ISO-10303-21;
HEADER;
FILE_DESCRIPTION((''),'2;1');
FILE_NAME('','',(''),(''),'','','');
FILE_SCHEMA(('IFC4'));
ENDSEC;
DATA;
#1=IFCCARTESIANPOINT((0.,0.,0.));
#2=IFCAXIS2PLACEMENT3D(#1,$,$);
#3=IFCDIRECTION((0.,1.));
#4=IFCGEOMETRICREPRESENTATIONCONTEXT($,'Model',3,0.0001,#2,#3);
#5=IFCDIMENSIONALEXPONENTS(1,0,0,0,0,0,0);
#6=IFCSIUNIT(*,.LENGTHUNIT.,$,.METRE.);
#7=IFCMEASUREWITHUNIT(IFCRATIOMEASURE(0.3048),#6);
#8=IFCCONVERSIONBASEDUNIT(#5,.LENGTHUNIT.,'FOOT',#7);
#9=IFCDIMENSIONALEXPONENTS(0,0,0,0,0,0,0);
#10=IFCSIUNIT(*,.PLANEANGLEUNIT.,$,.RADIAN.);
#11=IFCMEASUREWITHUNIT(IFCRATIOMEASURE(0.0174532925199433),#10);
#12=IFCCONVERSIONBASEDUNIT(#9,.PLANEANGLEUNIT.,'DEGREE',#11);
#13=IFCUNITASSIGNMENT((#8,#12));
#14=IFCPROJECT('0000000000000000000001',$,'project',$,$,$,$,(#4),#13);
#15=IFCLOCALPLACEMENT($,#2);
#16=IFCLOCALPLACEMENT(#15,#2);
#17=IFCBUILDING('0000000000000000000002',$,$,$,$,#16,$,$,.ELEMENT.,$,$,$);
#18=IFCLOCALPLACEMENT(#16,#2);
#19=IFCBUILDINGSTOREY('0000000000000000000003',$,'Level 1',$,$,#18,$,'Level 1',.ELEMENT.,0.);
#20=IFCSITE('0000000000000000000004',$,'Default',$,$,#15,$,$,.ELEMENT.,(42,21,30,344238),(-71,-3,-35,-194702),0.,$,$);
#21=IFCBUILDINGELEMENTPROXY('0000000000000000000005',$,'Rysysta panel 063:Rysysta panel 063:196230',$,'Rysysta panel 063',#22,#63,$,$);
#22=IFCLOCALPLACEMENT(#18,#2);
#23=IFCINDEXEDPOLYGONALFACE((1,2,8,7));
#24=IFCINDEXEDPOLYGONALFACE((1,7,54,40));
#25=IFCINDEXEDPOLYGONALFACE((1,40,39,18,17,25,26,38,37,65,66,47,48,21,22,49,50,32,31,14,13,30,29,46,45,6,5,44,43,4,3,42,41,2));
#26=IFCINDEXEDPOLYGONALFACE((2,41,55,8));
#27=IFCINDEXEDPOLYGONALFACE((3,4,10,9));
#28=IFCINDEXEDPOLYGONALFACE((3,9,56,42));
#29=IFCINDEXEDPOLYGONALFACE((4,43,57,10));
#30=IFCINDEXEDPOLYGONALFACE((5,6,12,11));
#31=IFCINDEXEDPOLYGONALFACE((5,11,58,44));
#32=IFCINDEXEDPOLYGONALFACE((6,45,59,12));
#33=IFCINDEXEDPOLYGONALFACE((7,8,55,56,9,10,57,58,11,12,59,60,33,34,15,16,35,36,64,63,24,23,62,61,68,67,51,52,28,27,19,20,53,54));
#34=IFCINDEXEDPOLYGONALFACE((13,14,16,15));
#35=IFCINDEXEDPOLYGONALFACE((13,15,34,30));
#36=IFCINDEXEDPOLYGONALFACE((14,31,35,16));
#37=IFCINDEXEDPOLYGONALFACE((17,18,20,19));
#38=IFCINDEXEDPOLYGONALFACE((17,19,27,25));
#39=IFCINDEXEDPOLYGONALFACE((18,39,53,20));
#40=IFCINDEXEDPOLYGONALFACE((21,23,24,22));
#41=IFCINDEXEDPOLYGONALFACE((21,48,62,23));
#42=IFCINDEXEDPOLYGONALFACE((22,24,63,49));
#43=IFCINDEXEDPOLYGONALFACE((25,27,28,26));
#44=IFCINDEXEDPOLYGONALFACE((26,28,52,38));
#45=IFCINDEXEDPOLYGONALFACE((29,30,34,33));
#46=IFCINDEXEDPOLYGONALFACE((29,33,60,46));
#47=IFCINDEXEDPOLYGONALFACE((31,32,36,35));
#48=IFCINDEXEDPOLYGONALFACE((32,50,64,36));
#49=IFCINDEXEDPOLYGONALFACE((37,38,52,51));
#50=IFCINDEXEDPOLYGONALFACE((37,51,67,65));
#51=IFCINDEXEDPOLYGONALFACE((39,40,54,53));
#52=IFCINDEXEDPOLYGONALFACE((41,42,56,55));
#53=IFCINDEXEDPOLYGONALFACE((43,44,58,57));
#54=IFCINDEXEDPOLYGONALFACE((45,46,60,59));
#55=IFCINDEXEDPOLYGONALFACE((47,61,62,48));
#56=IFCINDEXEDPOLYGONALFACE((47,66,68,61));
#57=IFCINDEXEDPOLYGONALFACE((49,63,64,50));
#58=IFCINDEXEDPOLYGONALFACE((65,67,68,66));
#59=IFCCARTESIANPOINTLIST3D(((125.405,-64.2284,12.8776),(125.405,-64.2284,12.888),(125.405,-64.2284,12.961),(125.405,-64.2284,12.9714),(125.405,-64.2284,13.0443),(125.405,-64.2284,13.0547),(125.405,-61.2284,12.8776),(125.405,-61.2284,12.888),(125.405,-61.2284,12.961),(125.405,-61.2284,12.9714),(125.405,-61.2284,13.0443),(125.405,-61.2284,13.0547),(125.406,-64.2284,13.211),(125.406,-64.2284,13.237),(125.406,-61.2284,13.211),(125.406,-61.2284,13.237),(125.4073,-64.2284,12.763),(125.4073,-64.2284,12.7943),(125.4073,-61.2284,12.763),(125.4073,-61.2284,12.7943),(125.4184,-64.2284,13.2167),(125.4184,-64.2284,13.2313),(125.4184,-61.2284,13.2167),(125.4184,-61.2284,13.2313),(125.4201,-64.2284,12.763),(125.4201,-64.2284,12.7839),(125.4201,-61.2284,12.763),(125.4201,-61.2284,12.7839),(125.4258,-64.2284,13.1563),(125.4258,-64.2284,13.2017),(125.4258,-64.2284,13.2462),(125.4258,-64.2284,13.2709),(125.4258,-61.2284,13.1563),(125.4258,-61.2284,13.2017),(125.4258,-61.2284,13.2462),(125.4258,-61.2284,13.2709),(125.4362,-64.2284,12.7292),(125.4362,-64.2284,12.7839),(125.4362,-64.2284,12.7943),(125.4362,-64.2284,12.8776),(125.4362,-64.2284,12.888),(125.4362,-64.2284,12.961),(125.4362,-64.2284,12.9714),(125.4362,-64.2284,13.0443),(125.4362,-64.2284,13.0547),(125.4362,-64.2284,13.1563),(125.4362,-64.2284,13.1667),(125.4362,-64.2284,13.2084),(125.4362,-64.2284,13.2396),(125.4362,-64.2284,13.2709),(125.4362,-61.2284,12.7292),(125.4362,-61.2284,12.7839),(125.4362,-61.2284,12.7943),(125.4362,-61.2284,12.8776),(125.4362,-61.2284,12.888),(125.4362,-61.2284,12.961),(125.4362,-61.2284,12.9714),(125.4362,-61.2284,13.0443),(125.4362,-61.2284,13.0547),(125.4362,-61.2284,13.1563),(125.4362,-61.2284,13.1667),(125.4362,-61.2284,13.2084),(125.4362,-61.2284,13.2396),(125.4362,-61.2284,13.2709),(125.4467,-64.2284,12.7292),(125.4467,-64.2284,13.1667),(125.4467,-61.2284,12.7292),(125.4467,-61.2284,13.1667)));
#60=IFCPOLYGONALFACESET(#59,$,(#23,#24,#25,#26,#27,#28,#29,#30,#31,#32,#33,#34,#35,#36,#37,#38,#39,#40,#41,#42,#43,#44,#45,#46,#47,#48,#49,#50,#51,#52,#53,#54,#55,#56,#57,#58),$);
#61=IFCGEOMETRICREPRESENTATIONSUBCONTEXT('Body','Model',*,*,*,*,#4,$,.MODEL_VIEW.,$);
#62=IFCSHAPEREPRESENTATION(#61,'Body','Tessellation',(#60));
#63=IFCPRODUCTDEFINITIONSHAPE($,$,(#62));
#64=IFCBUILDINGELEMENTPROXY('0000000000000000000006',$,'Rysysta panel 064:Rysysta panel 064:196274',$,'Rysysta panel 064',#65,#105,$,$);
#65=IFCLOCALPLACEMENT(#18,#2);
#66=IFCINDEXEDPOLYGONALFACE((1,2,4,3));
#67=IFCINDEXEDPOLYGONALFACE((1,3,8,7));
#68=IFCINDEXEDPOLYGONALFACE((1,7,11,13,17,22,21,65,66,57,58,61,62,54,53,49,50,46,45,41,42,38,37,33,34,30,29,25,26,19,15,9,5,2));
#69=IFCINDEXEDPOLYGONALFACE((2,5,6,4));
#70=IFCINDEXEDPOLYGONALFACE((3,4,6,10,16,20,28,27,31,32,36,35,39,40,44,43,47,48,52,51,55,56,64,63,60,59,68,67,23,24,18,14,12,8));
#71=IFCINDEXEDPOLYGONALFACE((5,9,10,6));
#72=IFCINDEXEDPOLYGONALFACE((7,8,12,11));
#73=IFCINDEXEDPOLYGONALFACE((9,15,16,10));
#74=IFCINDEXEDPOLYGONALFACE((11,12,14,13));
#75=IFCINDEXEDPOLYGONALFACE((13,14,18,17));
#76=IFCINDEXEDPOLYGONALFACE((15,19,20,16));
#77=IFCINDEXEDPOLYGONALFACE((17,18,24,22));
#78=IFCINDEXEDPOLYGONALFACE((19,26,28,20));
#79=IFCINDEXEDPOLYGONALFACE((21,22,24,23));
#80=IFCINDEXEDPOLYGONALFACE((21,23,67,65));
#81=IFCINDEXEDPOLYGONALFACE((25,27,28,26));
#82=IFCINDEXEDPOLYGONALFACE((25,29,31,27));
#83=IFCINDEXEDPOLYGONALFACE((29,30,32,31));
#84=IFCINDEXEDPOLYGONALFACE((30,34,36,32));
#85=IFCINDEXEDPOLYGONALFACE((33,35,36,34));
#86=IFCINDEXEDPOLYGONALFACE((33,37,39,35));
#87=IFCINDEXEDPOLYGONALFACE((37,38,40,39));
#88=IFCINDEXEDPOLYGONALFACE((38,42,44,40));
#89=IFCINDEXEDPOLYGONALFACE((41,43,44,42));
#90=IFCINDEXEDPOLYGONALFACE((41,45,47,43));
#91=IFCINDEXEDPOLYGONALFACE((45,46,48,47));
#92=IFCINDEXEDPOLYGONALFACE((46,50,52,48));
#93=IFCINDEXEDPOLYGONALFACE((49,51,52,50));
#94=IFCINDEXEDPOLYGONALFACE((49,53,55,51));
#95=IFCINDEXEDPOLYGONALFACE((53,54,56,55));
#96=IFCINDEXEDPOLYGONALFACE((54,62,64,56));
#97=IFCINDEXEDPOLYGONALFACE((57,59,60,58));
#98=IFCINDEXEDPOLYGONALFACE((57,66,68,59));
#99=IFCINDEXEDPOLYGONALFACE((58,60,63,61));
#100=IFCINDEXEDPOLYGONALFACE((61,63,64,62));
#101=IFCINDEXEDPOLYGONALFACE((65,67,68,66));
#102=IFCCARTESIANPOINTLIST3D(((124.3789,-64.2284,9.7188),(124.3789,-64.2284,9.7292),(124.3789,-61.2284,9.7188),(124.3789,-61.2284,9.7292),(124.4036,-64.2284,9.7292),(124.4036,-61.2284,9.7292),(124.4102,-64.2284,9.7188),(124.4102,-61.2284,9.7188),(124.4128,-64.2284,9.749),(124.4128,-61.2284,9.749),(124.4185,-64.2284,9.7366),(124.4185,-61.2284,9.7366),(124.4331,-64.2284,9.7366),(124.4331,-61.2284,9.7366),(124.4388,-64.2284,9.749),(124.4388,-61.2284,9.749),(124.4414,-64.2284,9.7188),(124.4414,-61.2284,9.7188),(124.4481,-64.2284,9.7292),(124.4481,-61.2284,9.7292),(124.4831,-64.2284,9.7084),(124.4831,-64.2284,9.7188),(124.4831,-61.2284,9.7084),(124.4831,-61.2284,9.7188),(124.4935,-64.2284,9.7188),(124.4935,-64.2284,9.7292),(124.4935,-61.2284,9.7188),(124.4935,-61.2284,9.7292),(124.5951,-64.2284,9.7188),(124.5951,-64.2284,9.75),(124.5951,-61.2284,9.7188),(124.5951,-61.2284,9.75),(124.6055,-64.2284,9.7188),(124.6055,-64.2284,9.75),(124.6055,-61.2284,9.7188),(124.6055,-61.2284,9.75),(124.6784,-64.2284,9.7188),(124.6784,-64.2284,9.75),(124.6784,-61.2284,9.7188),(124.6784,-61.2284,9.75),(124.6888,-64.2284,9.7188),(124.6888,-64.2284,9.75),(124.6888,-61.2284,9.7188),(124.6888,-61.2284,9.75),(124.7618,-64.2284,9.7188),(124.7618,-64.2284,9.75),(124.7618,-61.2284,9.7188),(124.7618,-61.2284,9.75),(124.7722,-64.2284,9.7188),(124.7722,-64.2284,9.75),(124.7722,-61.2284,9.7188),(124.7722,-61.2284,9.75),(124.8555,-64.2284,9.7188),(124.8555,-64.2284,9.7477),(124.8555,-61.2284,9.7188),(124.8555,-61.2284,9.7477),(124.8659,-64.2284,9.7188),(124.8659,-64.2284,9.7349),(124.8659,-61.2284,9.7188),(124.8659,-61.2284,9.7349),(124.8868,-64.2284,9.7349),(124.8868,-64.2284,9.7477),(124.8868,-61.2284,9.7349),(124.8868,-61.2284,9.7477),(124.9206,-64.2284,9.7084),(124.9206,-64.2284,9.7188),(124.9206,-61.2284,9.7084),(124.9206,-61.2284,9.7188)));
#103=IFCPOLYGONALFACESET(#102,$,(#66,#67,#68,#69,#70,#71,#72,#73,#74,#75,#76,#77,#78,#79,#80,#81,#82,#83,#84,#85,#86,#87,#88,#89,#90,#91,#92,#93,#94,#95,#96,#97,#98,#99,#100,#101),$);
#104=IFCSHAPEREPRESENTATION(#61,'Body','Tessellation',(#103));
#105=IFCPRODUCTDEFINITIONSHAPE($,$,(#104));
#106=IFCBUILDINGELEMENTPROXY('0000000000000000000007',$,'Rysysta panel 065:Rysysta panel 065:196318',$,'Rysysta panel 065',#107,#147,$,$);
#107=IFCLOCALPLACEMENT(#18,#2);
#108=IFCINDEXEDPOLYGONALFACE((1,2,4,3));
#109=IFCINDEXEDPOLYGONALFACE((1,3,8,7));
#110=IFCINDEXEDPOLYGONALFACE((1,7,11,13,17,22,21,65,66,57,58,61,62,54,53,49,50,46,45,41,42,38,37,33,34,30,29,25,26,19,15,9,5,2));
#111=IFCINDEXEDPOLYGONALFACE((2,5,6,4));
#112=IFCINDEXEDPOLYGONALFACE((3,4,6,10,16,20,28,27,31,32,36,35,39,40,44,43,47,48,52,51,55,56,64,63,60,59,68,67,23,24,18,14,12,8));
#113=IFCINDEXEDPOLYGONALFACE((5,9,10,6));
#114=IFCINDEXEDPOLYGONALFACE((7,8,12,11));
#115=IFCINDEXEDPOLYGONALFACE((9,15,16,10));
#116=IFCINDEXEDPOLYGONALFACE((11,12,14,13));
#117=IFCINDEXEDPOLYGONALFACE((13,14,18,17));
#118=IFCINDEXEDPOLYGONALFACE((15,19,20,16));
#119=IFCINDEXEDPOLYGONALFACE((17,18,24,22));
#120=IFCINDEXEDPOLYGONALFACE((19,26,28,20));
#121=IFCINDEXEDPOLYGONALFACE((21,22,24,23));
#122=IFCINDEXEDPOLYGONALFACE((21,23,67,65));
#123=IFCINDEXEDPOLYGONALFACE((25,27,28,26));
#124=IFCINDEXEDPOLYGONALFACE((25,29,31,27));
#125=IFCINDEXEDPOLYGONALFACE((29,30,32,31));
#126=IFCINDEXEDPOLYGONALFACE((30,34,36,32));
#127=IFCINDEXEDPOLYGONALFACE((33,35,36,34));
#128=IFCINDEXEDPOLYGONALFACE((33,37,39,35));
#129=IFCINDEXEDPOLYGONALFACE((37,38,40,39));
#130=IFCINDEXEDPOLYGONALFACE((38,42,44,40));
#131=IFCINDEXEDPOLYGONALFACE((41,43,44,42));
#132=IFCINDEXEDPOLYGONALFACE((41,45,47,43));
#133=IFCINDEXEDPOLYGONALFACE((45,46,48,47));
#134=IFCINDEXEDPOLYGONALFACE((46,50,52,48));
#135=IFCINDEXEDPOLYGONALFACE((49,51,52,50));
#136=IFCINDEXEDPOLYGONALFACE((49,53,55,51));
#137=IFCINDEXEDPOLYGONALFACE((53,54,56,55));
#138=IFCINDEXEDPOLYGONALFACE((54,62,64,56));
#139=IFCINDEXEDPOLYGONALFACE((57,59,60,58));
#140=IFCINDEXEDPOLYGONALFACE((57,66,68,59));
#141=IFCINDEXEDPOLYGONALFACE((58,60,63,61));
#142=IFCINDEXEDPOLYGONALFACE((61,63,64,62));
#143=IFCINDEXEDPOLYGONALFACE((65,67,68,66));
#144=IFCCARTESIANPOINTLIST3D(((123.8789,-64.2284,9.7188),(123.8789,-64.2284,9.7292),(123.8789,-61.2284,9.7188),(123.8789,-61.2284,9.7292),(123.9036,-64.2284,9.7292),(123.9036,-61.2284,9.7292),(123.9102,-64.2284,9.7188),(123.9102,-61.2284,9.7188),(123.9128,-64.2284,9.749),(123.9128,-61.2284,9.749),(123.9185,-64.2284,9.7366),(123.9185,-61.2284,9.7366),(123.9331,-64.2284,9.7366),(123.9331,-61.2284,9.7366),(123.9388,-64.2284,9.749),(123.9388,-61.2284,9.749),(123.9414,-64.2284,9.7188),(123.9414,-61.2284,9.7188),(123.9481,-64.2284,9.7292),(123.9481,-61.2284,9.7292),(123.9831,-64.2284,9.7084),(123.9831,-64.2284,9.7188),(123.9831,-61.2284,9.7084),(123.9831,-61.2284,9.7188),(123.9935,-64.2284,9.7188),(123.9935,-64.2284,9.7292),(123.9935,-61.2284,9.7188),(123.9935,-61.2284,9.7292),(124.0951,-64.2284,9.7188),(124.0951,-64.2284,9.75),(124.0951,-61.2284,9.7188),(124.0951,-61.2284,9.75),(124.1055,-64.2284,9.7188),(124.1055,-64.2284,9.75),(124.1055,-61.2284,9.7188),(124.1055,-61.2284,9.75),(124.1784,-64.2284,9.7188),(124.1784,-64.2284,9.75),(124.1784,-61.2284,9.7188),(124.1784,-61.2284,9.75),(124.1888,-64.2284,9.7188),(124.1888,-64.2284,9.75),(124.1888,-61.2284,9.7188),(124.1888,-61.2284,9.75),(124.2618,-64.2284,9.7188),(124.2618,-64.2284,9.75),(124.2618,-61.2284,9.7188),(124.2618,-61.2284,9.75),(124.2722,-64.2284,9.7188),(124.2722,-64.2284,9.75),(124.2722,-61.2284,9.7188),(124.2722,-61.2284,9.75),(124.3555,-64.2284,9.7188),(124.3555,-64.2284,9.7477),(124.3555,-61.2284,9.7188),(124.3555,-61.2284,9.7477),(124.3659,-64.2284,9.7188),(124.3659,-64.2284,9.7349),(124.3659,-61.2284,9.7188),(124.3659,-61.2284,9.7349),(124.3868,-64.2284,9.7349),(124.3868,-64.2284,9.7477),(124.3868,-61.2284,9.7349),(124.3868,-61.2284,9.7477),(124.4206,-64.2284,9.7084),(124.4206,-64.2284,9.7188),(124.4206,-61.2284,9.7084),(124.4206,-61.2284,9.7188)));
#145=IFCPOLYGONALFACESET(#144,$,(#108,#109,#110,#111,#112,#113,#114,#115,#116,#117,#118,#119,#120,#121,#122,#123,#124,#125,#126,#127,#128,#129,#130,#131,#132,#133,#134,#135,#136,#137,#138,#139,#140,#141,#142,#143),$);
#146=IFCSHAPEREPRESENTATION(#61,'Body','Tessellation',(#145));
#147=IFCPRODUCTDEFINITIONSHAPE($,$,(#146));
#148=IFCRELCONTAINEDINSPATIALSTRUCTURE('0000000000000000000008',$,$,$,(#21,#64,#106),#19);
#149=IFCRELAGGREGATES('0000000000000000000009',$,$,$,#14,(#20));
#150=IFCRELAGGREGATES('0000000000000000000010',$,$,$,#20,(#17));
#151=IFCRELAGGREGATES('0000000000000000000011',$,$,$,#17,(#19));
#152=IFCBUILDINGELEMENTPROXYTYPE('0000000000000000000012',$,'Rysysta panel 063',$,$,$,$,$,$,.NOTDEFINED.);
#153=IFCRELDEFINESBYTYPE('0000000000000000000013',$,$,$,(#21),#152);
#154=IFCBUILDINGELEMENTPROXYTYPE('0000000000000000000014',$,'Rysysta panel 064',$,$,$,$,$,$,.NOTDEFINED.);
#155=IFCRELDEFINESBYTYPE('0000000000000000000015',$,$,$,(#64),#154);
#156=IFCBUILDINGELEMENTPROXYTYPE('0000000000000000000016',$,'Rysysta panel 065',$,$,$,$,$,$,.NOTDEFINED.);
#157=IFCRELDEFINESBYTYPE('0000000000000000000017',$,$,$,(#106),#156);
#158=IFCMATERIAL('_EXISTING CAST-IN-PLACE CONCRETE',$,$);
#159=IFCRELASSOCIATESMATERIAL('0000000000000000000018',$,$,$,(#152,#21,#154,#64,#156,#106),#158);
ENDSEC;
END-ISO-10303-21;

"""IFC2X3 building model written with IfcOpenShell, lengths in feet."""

from ifc_helpers import new_model, entity, si_unit, converted_unit, direction, frame, origin, place, context, subcontext, project, spatial, polyline, outline, extrude, source, transform, mapped, material, type_object, type_shapes, element, save


model = new_model("IFC2X3")

# Units and contexts
model_context = context("Model", 3, precision=0.0001, world=origin(), true_north=direction((0.0, 1.0)))
body_context = subcontext(model_context, "Body", "Model", "MODEL_VIEW")
ifc_project = project(units=[converted_unit("LENGTHUNIT", "FOOT", entity("IfcRatioMeasure", 0.3048), si_unit("LENGTHUNIT", "METRE"), dimensions=[1, 0, 0, 0, 0, 0, 0]), converted_unit("PLANEANGLEUNIT", "DEGREE", entity("IfcRatioMeasure", 0.0174532925199433), si_unit("PLANEANGLEUNIT", "RADIAN"), dimensions=[0, 0, 0, 0, 0, 0, 0])], contexts=[model_context])

# Site, building, storey
site_placement = place(None, origin())
site = spatial("IfcSite", under=ifc_project, at=site_placement, Name="Default", CompositionType="ELEMENT", RefLatitude=(42, 21, 30, 344238), RefLongitude=(-71, -3, -35, -194702), RefElevation=0.0)
building_placement = place(site_placement, origin())
building = spatial("IfcBuilding", under=site, at=building_placement, CompositionType="ELEMENT")
storey_placement = place(building_placement, origin())
storey = spatial("IfcBuildingStorey", under=building, at=storey_placement, Name="Level 1", LongName="Level 1", CompositionType="ELEMENT", Elevation=0.0)

# Building element proxies
ifc_material_1 = material(Name="_EXISTING CAST-IN-PLACE CONCRETE")
building_element_proxy_type_1 = type_object("IfcBuildingElementProxyType", Name="Rysysta panel 063", PredefinedType="NOTDEFINED", material=ifc_material_1)
shared_shape_1 = source(origin(), body_context, "Body", "SweptSolid", [
    extrude(outline(polyline([(-0.1457, -0.022), (0.2918, -0.022), (0.2918, -0.0116), (0.2371, -0.0116), (0.2371, 0.0045), (0.258, 0.0045), (0.258, 0.0173), (0.2267, 0.0173), (0.2267, -0.0116), (0.1434, -0.0116), (0.1434, 0.0196), (0.133, 0.0196), (0.133, -0.0116), (0.06, -0.0116), (0.06, 0.0196), (0.0496, 0.0196), (0.0496, -0.0116), (-0.0233, -0.0116), (-0.0233, 0.0196), (-0.0337, 0.0196), (-0.0337, -0.0116), (-0.1353, -0.0116), (-0.1353, -0.0012), (-0.1807, -0.0012), (-0.1899, 0.0186), (-0.216, 0.0186), (-0.2252, -0.0012), (-0.2498, -0.0012), (-0.2498, -0.0116), (-0.2186, -0.0116), (-0.2103, 0.0062), (-0.1956, 0.0062), (-0.1873, -0.0116), (-0.1457, -0.0116), (-0.1457, -0.022)])), frame((125.4246, -64.2284, 13.021), z_axis=(0.0, 1.0, 0.0), x_axis=(0.0, 0.0, -1.0)), (0.0, 0.0, 1.0), 3.0),
])
type_shapes(building_element_proxy_type_1, [shared_shape_1])
proxy_1_placement = place(storey_placement, origin())
element("IfcBuildingElementProxy", 1, at=proxy_1_placement, inside=storey, type_object=building_element_proxy_type_1, material=ifc_material_1, Name="Rysysta panel 063:Rysysta panel 063:196230", ObjectType="Rysysta panel 063", context=body_context, shape_type="MappedRepresentation", body=[
    mapped(shared_shape_1, transform((0.0, 0.0, 0.0), scale=1.0)),
])
building_element_proxy_type_2 = type_object("IfcBuildingElementProxyType", Name="Rysysta panel 064", PredefinedType="NOTDEFINED", material=ifc_material_1)
shared_shape_2 = source(origin(), body_context, "Body", "SweptSolid", [
    extrude(outline(polyline([(0.0116, -0.2918), (0.022, -0.2918), (0.022, 0.1457), (0.0116, 0.1457), (0.0116, 0.1873), (-0.0062, 0.1956), (-0.0062, 0.2103), (0.0116, 0.2186), (0.0116, 0.2498), (0.0012, 0.2498), (0.0012, 0.2252), (-0.0186, 0.216), (-0.0186, 0.1899), (0.0012, 0.1807), (0.0012, 0.1353), (0.0116, 0.1353), (0.0116, 0.0337), (-0.0196, 0.0337), (-0.0196, 0.0233), (0.0116, 0.0233), (0.0116, -0.0496), (-0.0196, -0.0496), (-0.0196, -0.06), (0.0116, -0.06), (0.0116, -0.133), (-0.0196, -0.133), (-0.0196, -0.1434), (0.0116, -0.1434), (0.0116, -0.2267), (-0.0173, -0.2267), (-0.0173, -0.258), (-0.0045, -0.258), (-0.0045, -0.2371), (0.0116, -0.2371), (0.0116, -0.2918)])), frame((124.6288, -64.2284, 9.7304), z_axis=(0.0, 1.0, 0.0), x_axis=(0.0, 0.0, -1.0)), (0.0, 0.0, 1.0), 3.0),
])
type_shapes(building_element_proxy_type_2, [shared_shape_2])
proxy_2_placement = place(storey_placement, origin())
element("IfcBuildingElementProxy", 2, at=proxy_2_placement, inside=storey, type_object=building_element_proxy_type_2, material=ifc_material_1, Name="Rysysta panel 064:Rysysta panel 064:196274", ObjectType="Rysysta panel 064", context=body_context, shape_type="MappedRepresentation", body=[
    mapped(shared_shape_2, transform((0.0, 0.0, 0.0), scale=1.0)),
])
building_element_proxy_type_3 = type_object("IfcBuildingElementProxyType", Name="Rysysta panel 065", PredefinedType="NOTDEFINED", material=ifc_material_1)
shared_shape_3 = source(origin(), body_context, "Body", "SweptSolid", [
    extrude(outline(polyline([(0.0116, -0.2918), (0.022, -0.2918), (0.022, 0.1457), (0.0116, 0.1457), (0.0116, 0.1873), (-0.0062, 0.1956), (-0.0062, 0.2103), (0.0116, 0.2186), (0.0116, 0.2498), (0.0012, 0.2498), (0.0012, 0.2252), (-0.0186, 0.216), (-0.0186, 0.1899), (0.0012, 0.1807), (0.0012, 0.1353), (0.0116, 0.1353), (0.0116, 0.0337), (-0.0196, 0.0337), (-0.0196, 0.0233), (0.0116, 0.0233), (0.0116, -0.0496), (-0.0196, -0.0496), (-0.0196, -0.06), (0.0116, -0.06), (0.0116, -0.133), (-0.0196, -0.133), (-0.0196, -0.1434), (0.0116, -0.1434), (0.0116, -0.2267), (-0.0173, -0.2267), (-0.0173, -0.258), (-0.0045, -0.258), (-0.0045, -0.2371), (0.0116, -0.2371), (0.0116, -0.2918)])), frame((124.1288, -64.2284, 9.7304), z_axis=(0.0, 1.0, 0.0), x_axis=(0.0, 0.0, -1.0)), (0.0, 0.0, 1.0), 3.0),
])
type_shapes(building_element_proxy_type_3, [shared_shape_3])
proxy_3_placement = place(storey_placement, origin())
element("IfcBuildingElementProxy", 3, at=proxy_3_placement, inside=storey, type_object=building_element_proxy_type_3, material=ifc_material_1, Name="Rysysta panel 065:Rysysta panel 065:196318", ObjectType="Rysysta panel 065", context=body_context, shape_type="MappedRepresentation", body=[
    mapped(shared_shape_3, transform((0.0, 0.0, 0.0), scale=1.0)),
])

save(model, "model.ifc")
